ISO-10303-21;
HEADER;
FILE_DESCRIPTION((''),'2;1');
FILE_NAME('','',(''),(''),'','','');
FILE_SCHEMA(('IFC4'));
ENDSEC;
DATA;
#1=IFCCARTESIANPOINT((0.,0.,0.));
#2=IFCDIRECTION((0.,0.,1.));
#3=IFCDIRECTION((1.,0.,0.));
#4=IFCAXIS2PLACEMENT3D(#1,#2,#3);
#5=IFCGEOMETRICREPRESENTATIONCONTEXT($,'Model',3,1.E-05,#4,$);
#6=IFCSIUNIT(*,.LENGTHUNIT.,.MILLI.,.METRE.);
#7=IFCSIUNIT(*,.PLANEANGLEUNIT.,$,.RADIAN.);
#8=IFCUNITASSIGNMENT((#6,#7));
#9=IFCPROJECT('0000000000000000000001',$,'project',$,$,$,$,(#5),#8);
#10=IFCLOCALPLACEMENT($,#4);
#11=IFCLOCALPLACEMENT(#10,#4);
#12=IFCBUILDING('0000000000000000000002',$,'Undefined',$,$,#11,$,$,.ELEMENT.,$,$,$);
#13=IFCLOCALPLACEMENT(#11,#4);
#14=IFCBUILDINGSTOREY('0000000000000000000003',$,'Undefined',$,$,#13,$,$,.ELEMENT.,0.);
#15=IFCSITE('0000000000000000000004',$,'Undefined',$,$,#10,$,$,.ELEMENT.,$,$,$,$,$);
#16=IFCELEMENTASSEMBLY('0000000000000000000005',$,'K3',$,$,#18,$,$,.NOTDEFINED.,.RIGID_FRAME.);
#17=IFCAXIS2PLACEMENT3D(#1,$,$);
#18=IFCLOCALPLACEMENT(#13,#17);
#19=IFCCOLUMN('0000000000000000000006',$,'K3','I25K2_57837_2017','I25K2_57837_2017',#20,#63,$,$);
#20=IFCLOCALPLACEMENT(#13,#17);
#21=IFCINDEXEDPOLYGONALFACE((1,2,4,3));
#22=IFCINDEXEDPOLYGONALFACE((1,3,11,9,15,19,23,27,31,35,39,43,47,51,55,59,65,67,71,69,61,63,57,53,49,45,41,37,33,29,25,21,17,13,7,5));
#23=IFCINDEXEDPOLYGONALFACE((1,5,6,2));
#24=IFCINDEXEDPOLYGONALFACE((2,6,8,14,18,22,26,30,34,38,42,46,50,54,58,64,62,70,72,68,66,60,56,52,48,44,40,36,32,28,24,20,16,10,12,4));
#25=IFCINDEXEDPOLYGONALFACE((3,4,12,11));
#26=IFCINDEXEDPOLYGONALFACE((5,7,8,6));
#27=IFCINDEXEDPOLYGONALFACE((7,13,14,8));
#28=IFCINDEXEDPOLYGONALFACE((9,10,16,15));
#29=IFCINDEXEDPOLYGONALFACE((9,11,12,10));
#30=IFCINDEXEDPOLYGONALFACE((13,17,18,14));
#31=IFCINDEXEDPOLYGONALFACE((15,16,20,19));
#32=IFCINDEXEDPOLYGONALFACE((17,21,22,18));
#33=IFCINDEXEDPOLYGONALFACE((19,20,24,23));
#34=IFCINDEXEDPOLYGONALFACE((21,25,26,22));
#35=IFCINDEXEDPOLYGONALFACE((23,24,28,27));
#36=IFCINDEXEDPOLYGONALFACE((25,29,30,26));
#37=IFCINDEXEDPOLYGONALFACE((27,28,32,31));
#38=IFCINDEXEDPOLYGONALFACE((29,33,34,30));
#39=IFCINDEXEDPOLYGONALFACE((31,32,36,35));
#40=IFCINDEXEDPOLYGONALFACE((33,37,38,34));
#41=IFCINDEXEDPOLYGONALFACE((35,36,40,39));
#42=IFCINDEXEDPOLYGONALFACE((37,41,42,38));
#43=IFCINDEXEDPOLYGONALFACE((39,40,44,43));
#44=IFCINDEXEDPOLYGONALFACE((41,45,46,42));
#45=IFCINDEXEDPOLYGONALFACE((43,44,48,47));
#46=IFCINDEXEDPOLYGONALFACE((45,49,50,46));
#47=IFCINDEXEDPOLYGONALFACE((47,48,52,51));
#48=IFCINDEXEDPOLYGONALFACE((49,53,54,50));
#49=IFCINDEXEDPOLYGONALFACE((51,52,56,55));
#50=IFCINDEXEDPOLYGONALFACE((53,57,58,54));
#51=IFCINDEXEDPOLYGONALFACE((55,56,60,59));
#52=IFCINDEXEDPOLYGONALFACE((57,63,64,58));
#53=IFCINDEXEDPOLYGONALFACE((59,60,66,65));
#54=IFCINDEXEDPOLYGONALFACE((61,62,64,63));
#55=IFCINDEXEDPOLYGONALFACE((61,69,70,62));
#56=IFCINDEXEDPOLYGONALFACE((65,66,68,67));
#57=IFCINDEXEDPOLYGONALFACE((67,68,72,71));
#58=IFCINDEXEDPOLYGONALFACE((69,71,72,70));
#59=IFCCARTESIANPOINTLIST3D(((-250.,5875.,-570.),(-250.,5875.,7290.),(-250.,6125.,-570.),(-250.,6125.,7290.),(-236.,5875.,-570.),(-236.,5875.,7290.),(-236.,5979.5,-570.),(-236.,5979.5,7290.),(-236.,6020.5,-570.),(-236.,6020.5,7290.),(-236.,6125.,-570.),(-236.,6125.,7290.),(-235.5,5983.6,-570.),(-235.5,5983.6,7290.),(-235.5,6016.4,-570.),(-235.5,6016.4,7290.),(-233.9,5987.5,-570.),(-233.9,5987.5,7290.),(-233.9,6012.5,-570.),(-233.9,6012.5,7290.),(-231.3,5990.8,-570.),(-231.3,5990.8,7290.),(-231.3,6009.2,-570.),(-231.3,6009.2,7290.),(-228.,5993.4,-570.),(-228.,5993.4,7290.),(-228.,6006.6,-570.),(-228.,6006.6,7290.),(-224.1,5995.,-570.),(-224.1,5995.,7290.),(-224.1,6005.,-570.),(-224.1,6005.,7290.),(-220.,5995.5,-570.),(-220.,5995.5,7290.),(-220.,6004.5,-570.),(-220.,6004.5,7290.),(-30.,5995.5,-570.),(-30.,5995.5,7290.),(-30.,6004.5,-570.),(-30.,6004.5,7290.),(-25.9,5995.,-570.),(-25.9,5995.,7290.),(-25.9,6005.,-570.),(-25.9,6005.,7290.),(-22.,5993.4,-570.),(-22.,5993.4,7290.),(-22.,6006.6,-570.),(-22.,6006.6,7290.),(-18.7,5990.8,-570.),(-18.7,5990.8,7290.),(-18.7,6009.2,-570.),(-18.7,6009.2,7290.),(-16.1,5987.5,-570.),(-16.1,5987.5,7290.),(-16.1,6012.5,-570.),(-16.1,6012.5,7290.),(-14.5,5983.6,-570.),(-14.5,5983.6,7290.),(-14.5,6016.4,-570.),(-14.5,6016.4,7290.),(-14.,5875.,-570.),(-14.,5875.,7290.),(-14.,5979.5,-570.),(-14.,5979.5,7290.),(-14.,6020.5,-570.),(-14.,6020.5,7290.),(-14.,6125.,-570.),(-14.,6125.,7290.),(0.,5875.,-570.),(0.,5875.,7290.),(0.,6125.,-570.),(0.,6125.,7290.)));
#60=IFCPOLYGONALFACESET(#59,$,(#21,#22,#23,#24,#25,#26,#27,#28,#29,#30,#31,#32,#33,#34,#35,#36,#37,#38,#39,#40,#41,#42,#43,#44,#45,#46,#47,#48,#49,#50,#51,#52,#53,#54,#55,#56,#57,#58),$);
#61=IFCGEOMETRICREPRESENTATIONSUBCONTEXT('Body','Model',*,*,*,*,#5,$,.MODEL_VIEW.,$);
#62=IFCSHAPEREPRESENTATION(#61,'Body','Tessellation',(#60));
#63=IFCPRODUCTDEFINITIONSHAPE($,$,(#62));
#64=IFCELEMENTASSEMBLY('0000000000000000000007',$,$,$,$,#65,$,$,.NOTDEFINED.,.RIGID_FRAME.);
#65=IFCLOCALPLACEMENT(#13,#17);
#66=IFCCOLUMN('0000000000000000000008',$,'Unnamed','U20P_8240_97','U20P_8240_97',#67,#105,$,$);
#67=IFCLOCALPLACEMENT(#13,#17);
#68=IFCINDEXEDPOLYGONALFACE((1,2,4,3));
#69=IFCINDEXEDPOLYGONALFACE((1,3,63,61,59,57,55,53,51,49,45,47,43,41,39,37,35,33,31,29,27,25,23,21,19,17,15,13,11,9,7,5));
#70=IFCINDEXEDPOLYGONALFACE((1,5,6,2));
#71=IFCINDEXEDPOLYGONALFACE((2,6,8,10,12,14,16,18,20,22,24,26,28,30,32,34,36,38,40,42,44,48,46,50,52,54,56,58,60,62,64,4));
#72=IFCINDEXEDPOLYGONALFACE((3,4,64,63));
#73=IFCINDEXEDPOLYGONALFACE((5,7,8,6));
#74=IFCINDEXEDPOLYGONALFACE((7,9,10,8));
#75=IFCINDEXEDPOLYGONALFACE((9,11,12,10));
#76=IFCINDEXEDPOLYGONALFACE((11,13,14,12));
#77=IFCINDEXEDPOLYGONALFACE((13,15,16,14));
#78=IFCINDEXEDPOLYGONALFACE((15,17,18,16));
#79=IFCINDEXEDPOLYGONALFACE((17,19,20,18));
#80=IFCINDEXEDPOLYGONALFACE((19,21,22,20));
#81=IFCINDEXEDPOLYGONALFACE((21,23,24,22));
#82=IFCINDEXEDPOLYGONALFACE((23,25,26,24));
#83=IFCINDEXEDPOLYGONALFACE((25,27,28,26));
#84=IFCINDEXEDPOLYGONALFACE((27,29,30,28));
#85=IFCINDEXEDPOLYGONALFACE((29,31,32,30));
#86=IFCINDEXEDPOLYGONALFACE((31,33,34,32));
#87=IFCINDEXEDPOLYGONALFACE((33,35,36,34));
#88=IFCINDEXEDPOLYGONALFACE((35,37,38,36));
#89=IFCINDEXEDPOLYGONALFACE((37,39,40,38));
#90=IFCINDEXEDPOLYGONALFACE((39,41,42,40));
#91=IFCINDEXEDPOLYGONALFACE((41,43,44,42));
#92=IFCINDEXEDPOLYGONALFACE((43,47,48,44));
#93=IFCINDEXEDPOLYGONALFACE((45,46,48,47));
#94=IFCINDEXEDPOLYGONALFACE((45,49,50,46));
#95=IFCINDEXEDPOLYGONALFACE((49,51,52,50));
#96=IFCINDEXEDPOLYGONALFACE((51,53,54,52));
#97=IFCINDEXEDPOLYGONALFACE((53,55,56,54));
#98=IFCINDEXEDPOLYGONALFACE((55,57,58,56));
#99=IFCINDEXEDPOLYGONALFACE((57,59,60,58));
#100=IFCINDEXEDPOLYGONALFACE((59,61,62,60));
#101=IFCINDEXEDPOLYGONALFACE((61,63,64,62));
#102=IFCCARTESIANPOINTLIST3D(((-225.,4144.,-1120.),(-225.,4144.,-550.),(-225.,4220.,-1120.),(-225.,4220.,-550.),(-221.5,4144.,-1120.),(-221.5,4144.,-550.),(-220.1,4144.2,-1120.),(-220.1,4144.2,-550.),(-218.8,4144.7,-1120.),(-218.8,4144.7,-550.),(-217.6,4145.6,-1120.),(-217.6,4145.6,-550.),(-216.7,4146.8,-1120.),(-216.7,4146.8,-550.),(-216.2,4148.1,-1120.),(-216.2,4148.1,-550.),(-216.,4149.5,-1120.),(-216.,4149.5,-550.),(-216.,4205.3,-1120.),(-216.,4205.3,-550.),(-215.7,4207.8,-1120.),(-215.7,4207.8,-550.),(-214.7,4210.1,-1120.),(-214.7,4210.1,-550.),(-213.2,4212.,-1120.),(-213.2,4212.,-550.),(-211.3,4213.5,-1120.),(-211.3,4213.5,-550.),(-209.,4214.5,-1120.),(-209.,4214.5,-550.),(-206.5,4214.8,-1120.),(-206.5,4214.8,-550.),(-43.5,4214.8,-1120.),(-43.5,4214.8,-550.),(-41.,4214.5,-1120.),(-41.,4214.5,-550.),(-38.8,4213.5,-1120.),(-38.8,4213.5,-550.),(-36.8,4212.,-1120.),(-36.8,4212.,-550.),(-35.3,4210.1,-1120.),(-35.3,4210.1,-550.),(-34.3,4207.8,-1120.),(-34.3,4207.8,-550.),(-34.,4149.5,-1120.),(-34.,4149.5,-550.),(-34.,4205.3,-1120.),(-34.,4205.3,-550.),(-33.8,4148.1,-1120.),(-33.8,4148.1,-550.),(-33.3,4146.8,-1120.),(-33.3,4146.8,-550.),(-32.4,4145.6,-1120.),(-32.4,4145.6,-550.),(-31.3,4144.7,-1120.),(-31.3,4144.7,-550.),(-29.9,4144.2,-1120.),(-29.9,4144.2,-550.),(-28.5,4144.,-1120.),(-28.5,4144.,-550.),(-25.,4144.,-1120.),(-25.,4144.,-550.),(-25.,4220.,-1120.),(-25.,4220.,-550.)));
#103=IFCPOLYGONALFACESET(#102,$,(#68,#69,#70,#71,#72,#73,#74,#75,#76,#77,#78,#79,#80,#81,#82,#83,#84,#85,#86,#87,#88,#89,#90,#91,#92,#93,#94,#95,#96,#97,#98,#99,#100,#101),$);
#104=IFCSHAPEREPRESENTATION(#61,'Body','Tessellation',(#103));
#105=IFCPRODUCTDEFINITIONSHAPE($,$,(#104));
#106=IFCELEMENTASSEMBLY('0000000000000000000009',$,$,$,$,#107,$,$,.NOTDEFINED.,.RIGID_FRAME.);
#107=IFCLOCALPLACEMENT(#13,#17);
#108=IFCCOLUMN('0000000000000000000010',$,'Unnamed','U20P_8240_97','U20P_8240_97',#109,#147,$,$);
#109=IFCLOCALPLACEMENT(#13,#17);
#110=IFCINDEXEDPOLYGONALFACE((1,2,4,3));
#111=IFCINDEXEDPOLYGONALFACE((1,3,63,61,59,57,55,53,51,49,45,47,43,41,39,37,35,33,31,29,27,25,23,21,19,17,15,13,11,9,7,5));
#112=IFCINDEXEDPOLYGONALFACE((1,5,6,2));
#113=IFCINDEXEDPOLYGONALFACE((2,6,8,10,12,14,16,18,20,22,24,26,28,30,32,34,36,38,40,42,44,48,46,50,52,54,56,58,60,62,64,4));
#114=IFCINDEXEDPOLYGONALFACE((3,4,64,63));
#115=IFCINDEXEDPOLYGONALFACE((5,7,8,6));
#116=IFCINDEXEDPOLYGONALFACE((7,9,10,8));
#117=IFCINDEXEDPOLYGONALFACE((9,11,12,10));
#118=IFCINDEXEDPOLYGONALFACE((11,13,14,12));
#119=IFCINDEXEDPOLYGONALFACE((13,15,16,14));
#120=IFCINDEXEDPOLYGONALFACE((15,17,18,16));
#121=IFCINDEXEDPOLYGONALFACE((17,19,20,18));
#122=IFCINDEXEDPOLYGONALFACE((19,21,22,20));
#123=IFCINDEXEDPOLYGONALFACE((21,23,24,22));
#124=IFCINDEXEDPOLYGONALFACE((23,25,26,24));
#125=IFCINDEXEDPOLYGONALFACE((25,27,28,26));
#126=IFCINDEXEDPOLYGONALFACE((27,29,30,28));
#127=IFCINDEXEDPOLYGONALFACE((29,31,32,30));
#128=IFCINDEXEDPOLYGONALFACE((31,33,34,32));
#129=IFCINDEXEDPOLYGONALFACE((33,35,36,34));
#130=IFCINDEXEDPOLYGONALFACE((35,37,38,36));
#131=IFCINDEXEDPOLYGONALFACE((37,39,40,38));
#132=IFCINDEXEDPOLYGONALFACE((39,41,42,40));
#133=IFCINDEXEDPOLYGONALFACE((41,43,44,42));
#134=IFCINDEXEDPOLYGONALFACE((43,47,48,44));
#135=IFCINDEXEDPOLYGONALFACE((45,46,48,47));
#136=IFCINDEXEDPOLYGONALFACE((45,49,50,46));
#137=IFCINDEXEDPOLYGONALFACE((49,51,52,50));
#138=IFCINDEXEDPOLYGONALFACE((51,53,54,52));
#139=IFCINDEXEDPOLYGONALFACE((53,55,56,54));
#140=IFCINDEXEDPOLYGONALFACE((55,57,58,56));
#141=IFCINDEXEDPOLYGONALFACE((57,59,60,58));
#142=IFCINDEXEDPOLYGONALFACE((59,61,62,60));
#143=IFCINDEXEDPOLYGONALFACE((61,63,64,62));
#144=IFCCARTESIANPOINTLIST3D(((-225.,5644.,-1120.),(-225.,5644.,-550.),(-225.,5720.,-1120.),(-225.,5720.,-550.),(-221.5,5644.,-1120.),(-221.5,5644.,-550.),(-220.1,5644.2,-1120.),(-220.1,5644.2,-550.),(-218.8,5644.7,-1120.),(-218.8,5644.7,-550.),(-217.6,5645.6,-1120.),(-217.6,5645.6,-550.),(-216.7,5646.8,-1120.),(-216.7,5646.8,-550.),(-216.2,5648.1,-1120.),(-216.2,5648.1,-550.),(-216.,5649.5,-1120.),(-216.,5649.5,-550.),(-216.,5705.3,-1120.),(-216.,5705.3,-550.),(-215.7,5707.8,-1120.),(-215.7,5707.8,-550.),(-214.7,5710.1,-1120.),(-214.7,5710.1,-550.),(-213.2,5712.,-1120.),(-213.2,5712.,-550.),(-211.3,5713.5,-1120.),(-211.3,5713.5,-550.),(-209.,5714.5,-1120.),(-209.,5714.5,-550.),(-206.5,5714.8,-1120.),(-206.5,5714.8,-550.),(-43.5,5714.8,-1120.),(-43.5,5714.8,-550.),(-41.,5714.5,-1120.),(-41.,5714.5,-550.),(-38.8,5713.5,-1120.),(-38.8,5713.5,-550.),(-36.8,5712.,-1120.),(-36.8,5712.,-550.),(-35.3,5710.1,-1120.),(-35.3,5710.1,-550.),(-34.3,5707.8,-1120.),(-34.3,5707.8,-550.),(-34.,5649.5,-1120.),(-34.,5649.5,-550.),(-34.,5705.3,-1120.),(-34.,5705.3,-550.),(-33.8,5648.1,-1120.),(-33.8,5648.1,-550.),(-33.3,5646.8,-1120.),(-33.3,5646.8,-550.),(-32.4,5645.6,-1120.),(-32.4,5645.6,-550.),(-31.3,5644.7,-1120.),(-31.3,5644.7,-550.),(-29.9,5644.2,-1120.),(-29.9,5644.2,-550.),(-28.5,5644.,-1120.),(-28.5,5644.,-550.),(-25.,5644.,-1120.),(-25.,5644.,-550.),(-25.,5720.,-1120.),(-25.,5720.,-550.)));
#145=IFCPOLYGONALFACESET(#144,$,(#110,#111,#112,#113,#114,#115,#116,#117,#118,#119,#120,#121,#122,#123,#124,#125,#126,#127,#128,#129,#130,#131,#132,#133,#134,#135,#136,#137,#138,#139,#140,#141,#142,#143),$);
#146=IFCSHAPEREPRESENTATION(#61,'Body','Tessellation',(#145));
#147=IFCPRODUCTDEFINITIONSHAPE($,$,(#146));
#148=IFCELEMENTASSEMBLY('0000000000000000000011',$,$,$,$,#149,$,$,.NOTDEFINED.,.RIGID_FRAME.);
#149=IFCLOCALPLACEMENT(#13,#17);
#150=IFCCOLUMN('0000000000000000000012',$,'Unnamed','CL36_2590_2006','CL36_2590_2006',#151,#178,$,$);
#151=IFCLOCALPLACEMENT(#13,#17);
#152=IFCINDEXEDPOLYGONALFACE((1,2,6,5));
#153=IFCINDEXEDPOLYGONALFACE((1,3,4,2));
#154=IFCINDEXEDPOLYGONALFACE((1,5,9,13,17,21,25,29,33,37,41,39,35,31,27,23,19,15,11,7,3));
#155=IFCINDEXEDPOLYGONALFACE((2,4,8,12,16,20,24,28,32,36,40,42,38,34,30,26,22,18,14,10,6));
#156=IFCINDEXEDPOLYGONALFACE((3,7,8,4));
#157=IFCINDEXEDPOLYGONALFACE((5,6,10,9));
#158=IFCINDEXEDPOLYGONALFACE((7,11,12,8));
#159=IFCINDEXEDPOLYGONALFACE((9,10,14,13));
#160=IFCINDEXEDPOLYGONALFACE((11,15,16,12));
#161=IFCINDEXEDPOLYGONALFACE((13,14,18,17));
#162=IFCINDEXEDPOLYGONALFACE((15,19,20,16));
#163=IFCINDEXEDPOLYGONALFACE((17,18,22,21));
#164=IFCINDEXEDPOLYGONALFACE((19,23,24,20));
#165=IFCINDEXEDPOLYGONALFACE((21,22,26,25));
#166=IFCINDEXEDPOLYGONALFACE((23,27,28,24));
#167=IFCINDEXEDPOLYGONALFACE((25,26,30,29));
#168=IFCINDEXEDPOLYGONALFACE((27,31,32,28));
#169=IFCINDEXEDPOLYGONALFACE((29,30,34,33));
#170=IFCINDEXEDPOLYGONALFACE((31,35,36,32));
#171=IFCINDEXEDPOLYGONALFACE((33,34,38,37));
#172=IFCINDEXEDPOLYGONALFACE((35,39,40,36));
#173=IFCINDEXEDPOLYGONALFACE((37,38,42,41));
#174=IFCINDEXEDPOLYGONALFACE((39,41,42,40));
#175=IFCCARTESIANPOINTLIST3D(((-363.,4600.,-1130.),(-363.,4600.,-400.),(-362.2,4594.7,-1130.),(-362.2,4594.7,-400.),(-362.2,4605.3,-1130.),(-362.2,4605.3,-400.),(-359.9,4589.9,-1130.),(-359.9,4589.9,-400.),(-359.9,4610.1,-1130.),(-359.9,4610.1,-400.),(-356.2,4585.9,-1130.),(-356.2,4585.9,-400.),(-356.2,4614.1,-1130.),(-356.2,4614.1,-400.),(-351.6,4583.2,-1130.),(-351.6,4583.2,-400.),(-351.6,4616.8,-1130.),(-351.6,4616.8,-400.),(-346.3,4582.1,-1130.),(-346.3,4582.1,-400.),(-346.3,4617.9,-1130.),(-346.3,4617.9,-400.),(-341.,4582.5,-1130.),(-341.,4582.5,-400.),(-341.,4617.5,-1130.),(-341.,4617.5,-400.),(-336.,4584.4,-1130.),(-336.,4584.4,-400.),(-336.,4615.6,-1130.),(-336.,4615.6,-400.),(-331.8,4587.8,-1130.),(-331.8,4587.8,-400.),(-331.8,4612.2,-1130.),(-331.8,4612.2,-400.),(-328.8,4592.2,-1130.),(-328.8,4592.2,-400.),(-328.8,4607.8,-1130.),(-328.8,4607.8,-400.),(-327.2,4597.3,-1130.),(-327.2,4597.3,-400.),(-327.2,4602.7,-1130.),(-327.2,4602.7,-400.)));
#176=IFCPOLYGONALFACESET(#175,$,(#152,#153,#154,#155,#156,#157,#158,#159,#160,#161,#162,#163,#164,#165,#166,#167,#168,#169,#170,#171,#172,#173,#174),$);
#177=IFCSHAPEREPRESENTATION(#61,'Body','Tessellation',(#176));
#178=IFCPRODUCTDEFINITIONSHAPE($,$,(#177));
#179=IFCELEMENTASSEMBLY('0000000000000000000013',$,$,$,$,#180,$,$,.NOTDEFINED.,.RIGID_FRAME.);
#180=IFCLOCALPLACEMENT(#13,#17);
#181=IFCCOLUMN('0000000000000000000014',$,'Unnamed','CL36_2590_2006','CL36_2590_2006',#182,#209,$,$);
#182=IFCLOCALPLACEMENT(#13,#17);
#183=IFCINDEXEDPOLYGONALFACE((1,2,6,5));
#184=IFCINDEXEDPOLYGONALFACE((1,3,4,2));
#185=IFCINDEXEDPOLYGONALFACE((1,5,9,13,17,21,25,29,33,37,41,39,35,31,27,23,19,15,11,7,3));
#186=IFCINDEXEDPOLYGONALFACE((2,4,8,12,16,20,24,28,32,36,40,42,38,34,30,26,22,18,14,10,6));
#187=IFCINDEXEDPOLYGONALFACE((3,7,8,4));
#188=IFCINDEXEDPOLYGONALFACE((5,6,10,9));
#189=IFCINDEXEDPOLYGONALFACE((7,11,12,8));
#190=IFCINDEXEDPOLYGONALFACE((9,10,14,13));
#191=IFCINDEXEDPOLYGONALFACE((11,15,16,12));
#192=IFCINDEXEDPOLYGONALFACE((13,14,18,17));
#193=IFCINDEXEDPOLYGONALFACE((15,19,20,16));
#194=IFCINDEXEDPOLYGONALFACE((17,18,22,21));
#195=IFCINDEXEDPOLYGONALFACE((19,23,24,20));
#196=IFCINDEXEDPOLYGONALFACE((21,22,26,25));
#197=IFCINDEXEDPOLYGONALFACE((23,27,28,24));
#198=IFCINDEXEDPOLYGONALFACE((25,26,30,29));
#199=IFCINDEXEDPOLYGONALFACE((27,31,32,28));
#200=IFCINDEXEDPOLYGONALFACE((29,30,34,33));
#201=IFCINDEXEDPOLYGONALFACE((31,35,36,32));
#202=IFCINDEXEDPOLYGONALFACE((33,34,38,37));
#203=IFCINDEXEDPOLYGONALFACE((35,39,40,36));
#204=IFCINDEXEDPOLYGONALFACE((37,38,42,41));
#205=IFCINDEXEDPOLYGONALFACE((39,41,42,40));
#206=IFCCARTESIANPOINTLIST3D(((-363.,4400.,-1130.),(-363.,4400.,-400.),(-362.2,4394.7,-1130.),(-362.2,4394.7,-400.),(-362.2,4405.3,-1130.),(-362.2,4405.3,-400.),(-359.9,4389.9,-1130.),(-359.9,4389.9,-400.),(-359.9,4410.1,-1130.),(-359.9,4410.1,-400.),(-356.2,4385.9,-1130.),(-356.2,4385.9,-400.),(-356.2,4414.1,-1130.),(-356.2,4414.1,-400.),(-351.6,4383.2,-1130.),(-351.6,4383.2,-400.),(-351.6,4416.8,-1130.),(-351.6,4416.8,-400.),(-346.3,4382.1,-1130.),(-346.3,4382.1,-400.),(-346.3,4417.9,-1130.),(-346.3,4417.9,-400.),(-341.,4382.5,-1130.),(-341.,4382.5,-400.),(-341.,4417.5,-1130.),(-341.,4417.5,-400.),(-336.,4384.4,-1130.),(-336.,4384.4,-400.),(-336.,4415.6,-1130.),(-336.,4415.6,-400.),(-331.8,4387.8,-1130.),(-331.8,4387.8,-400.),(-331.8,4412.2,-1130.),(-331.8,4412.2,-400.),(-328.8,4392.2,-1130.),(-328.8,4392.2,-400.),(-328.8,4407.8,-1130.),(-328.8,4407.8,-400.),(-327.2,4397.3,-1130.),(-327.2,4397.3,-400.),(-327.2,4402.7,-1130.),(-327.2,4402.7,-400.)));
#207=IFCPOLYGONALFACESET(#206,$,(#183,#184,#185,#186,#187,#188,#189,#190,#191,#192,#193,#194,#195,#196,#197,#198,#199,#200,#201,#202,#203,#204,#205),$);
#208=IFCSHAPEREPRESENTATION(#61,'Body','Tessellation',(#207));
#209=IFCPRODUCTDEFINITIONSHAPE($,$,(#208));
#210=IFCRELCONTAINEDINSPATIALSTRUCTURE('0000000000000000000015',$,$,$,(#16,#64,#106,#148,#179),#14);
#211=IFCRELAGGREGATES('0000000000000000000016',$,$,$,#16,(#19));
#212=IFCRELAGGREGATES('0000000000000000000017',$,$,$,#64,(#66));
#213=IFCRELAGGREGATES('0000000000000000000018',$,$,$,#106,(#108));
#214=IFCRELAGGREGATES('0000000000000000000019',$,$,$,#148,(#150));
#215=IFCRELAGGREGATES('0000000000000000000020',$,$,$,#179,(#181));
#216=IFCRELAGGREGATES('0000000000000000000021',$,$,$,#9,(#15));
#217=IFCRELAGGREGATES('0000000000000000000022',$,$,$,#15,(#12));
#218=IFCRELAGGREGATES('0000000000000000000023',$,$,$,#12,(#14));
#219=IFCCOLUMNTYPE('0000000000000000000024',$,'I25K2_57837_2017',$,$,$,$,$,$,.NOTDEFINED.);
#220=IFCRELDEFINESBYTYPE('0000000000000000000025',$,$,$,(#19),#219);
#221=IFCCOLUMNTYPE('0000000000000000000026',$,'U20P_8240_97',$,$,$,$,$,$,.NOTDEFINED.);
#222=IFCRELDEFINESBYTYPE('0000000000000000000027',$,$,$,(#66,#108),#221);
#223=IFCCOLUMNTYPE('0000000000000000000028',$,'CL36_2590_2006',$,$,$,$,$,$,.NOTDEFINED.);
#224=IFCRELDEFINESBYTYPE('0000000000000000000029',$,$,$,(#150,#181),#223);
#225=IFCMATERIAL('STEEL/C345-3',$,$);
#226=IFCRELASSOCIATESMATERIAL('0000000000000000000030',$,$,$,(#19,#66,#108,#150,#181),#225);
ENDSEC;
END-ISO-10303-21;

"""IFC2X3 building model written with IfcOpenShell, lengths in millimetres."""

from ifc_helpers import new_model, si_unit, frame, origin_with_axes, origin_2d_with_axis, place, context, subcontext, project, spatial, circle, i_section, u_section, extrude, material, type_object, element, aggregate, save


model = new_model("IFC2X3")

# Units and contexts
model_context = context("Model", 3, precision=1e-05, world=origin_with_axes())
body_context = subcontext(model_context, "Body", "Model", "MODEL_VIEW")
ifc_project = project(units=[si_unit("LENGTHUNIT", "METRE", prefix="MILLI"), si_unit("PLANEANGLEUNIT", "RADIAN")], contexts=[model_context])

# Site, building, storey
site_placement = place(None, origin_with_axes())
site = spatial("IfcSite", under=ifc_project, at=site_placement, Name="Undefined", CompositionType="ELEMENT")
building_placement = place(site_placement, origin_with_axes())
building = spatial("IfcBuilding", under=site, at=building_placement, Name="Undefined", CompositionType="ELEMENT")
storey_placement = place(building_placement, origin_with_axes())
storey = spatial("IfcBuildingStorey", under=building, at=storey_placement, Name="Undefined", CompositionType="ELEMENT", Elevation=0.0)

# Element assemblies, columns
ifc_material_1 = material(Name="STEEL/C345-3")
column_type_1 = type_object("IfcColumnType", Name="I25K2_57837_2017", PredefinedType="NOTDEFINED")
assembly_1_placement = place(storey_placement, origin_with_axes())
assembly_1 = element("IfcElementAssembly", 1, at=assembly_1_placement, inside=storey, Name="K3", AssemblyPlace="NOTDEFINED", PredefinedType="RIGID_FRAME")
column_1_placement = place(assembly_1_placement, frame((-125.0, 6000.0, -570.0), z_axis=(0.0, 0.0, 1.0), x_axis=(-1.0, 0.0, 0.0)))
column_1 = element("IfcColumn", 2, at=column_1_placement, type_object=column_type_1, material=ifc_material_1, Name="K3", Description="I25K2_57837_2017", ObjectType="I25K2_57837_2017", context=body_context, shape_type="SweptSolid", body=[
    extrude(i_section(OverallWidth=250.0, OverallDepth=250.0, WebThickness=9.0, FlangeThickness=14.0, FilletRadius=16.0, at=origin_2d_with_axis()), frame((0.0, 0.0, 7860.0), z_axis=(0.0, 0.0, -1.0), x_axis=(0.0, 1.0, 0.0)), (0.0, 0.0, 1.0), 7860.0),
])
aggregate(assembly_1, [column_1])
assembly_2_placement = place(storey_placement, origin_with_axes())
assembly_2 = element("IfcElementAssembly", 3, at=assembly_2_placement, inside=storey, AssemblyPlace="NOTDEFINED", PredefinedType="RIGID_FRAME")
column_type_2 = type_object("IfcColumnType", Name="U20P_8240_97", PredefinedType="NOTDEFINED")
column_2_placement = place(assembly_2_placement, frame((-125.0, 4182.0, -1120.0), z_axis=(0.0, 0.0, 1.0), x_axis=(-1.0, 0.0, 0.0)))
column_2 = element("IfcColumn", 4, at=column_2_placement, type_object=column_type_2, material=ifc_material_1, Name="Unnamed", Description="U20P_8240_97", ObjectType="U20P_8240_97", context=body_context, shape_type="SweptSolid", body=[
    extrude(u_section(Depth=200.0, FlangeWidth=76.0, WebThickness=5.2, FlangeThickness=9.0, FilletRadius=9.5, EdgeRadius=5.5, at=origin_2d_with_axis()), frame((0.0, 0.0, 570.0), z_axis=(0.0, 0.0, -1.0), x_axis=(0.0, 1.0, 0.0)), (0.0, 0.0, 1.0), 570.0),
])
aggregate(assembly_2, [column_2])
assembly_3_placement = place(storey_placement, origin_with_axes())
assembly_3 = element("IfcElementAssembly", 5, at=assembly_3_placement, inside=storey, AssemblyPlace="NOTDEFINED", PredefinedType="RIGID_FRAME")
column_3_placement = place(assembly_3_placement, frame((-125.0, 5682.0, -1120.0), z_axis=(0.0, 0.0, 1.0), x_axis=(-1.0, 0.0, 0.0)))
column_3 = element("IfcColumn", 6, at=column_3_placement, type_object=column_type_2, material=ifc_material_1, Name="Unnamed", Description="U20P_8240_97", ObjectType="U20P_8240_97", context=body_context, shape_type="SweptSolid", body=[
    extrude(u_section(Depth=200.0, FlangeWidth=76.0, WebThickness=5.2, FlangeThickness=9.0, FilletRadius=9.5, EdgeRadius=5.5, at=origin_2d_with_axis()), frame((0.0, 0.0, 570.0), z_axis=(0.0, 0.0, -1.0), x_axis=(0.0, 1.0, 0.0)), (0.0, 0.0, 1.0), 570.0),
])
aggregate(assembly_3, [column_3])
assembly_4_placement = place(storey_placement, origin_with_axes())
assembly_4 = element("IfcElementAssembly", 7, at=assembly_4_placement, inside=storey, AssemblyPlace="NOTDEFINED", PredefinedType="RIGID_FRAME")
column_type_3 = type_object("IfcColumnType", Name="CL36_2590_2006", PredefinedType="NOTDEFINED")
column_4_placement = place(assembly_4_placement, frame((-345.0, 4600.0, -1130.0), z_axis=(0.0, 0.0, 1.0), x_axis=(0.0, 1.0, 0.0)))
column_4 = element("IfcColumn", 8, at=column_4_placement, type_object=column_type_3, material=ifc_material_1, Name="Unnamed", Description="CL36_2590_2006", ObjectType="CL36_2590_2006", context=body_context, shape_type="SweptSolid", body=[
    extrude(circle(Radius=18.0, at=origin_2d_with_axis()), frame((0.0, 0.0, 730.0), z_axis=(0.0, 0.0, -1.0), x_axis=(0.0, 1.0, 0.0)), (0.0, 0.0, 1.0), 730.0),
])
aggregate(assembly_4, [column_4])
assembly_5_placement = place(storey_placement, origin_with_axes())
assembly_5 = element("IfcElementAssembly", 9, at=assembly_5_placement, inside=storey, AssemblyPlace="NOTDEFINED", PredefinedType="RIGID_FRAME")
column_5_placement = place(assembly_5_placement, frame((-345.0, 4400.0, -1130.0), z_axis=(0.0, 0.0, 1.0), x_axis=(0.0, 1.0, 0.0)))
column_5 = element("IfcColumn", 10, at=column_5_placement, type_object=column_type_3, material=ifc_material_1, Name="Unnamed", Description="CL36_2590_2006", ObjectType="CL36_2590_2006", context=body_context, shape_type="SweptSolid", body=[
    extrude(circle(Radius=18.0, at=origin_2d_with_axis()), frame((0.0, 0.0, 730.0), z_axis=(0.0, 0.0, -1.0), x_axis=(0.0, 1.0, 0.0)), (0.0, 0.0, 1.0), 730.0),
])
aggregate(assembly_5, [column_5])

save(model, "model.ifc")
